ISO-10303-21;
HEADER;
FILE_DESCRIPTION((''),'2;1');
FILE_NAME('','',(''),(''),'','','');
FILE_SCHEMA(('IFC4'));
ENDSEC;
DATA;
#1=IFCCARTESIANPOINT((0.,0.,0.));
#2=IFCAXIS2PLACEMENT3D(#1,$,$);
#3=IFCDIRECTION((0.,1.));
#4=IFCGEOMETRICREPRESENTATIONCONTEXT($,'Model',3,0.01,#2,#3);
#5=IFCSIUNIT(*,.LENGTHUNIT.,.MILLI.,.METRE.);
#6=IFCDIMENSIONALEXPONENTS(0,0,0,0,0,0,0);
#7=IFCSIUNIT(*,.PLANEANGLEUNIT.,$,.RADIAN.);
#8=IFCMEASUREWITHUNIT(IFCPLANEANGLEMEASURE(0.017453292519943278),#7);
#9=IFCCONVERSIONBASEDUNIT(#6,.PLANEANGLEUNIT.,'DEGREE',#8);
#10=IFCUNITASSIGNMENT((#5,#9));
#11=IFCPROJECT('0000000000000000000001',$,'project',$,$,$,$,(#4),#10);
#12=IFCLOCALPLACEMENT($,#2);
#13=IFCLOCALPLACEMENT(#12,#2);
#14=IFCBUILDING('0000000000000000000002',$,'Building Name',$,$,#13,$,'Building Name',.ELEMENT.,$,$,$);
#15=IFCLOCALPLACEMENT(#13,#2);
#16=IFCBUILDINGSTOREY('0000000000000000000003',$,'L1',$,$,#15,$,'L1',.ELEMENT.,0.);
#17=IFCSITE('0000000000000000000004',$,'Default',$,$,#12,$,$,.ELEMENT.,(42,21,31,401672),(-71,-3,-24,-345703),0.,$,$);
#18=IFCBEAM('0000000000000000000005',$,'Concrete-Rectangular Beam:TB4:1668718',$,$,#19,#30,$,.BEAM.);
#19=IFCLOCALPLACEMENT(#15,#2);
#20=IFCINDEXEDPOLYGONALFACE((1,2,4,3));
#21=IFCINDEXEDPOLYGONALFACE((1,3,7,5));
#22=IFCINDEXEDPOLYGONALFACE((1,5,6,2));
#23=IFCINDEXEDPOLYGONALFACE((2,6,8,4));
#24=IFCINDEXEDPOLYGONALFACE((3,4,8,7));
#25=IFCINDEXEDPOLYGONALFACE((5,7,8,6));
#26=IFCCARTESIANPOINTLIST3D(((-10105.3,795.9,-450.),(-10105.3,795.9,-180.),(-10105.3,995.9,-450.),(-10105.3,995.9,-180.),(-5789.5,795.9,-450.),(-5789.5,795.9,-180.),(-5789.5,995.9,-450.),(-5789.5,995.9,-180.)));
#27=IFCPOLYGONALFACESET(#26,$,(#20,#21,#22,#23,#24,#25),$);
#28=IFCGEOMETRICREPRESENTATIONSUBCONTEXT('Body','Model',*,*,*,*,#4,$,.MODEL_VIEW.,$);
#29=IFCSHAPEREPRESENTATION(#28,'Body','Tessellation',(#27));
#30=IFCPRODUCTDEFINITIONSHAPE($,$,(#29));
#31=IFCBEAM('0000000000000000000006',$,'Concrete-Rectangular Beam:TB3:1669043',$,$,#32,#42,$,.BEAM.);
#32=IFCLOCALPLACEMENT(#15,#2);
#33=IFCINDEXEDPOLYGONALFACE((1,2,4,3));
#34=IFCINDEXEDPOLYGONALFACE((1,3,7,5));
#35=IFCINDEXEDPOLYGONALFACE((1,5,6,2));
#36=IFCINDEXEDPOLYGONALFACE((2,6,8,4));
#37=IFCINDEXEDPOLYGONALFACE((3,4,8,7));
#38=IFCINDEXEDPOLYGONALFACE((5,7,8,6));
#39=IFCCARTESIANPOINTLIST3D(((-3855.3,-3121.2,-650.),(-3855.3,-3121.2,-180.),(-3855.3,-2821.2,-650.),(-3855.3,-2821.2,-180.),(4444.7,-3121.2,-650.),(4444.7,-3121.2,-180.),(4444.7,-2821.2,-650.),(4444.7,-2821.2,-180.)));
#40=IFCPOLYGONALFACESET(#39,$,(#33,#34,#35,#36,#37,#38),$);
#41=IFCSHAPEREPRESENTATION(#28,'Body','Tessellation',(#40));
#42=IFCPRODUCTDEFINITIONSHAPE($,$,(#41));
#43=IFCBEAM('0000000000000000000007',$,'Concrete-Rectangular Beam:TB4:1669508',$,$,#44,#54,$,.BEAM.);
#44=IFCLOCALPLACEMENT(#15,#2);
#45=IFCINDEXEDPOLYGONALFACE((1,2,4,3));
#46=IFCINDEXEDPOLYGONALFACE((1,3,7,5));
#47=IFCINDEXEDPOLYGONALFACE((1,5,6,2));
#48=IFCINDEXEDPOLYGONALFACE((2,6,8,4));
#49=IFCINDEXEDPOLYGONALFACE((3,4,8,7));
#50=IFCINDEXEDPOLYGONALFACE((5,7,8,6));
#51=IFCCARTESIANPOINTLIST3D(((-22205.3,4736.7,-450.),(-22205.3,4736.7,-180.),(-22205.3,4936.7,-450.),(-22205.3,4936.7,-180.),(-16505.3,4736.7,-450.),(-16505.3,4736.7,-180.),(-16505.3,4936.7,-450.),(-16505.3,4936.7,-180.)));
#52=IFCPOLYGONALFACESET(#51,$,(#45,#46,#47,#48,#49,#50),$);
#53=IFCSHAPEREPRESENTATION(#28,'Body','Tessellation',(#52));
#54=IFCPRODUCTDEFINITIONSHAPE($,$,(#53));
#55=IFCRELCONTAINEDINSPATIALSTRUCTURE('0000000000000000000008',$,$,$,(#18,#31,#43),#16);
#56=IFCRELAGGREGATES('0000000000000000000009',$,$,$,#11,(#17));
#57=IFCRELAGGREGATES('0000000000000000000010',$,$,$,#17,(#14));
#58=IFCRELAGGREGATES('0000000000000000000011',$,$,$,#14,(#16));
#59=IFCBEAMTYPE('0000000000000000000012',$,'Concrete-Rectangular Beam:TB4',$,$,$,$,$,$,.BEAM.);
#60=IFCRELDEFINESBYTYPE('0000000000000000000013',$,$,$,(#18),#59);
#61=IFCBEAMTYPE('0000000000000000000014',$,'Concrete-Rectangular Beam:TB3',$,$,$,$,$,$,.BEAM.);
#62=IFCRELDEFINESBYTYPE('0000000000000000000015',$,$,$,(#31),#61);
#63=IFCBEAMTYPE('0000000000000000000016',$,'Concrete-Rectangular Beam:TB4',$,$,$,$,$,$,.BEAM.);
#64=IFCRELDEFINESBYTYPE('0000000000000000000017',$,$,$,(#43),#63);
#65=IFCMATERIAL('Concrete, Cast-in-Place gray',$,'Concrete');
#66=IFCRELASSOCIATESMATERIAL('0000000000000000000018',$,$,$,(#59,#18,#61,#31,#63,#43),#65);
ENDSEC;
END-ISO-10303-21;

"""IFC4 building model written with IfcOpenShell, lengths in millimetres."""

from ifc_helpers import new_model, entity, si_unit, converted_unit, direction, frame, origin, place, context, subcontext, project, spatial, indexed_curve, outline, extrude, source, transform, mapped, material, type_object, type_shapes, element, save


model = new_model("IFC4")

# Units and contexts
model_context = context("Model", 3, precision=0.01, world=origin(), true_north=direction((0.0, 1.0)))
body_context = subcontext(model_context, "Body", "Model", "MODEL_VIEW")
ifc_project = project(units=[si_unit("LENGTHUNIT", "METRE", prefix="MILLI"), converted_unit("PLANEANGLEUNIT", "DEGREE", entity("IfcPlaneAngleMeasure", 0.017453292519943278), si_unit("PLANEANGLEUNIT", "RADIAN"), dimensions=[0, 0, 0, 0, 0, 0, 0])], contexts=[model_context])

# Site, building, storey
site_placement = place(None, origin())
site = spatial("IfcSite", under=ifc_project, at=site_placement, Name="Default", CompositionType="ELEMENT", RefLatitude=(42, 21, 31, 401672), RefLongitude=(-71, -3, -24, -345703), RefElevation=0.0)
building_placement = place(site_placement, origin())
building = spatial("IfcBuilding", under=site, at=building_placement, Name="Building Name", LongName="Building Name", CompositionType="ELEMENT")
storey_placement = place(building_placement, origin())
storey = spatial("IfcBuildingStorey", under=building, at=storey_placement, Name="L1", LongName="L1", CompositionType="ELEMENT", Elevation=0.0)

# Beams
ifc_material = material(Name="Concrete, Cast-in-Place gray", Category="Concrete")
beam_type_1 = type_object("IfcBeamType", Name="Concrete-Rectangular Beam:TB4", PredefinedType="BEAM", material=ifc_material)
shared_shape_1 = source(origin(), body_context, "Body", "SweptSolid", [
    extrude(outline(indexed_curve([(-135.0, -100.0), (135.0, -100.0), (135.0, 100.0), (-135.0, 100.0), (-135.0, -100.0)], self_intersect=False)), frame((-10105.3, 895.9, -315.0), z_axis=(1.0, 0.0, 0.0), x_axis=(0.0, 0.0, -1.0)), (0.0, 0.0, 1.0), 4315.8),
])
type_shapes(beam_type_1, [shared_shape_1])
beam_1_placement = place(storey_placement, origin())
element("IfcBeam", 1, at=beam_1_placement, inside=storey, type_object=beam_type_1, material=ifc_material, Name="Concrete-Rectangular Beam:TB4:1668718", PredefinedType="BEAM", context=body_context, shape_type="MappedRepresentation", body=[
    mapped(shared_shape_1, transform((0.0, 0.0, 0.0), scale=1.0)),
])
beam_type_2 = type_object("IfcBeamType", Name="Concrete-Rectangular Beam:TB3", PredefinedType="BEAM", material=ifc_material)
shared_shape_2 = source(origin(), body_context, "Body", "SweptSolid", [
    extrude(outline(indexed_curve([(-235.0, -150.0), (235.0, -150.0), (235.0, 150.0), (-235.0, 150.0), (-235.0, -150.0)], self_intersect=False)), frame((-3855.3, -2971.2, -415.0), z_axis=(1.0, 0.0, 0.0), x_axis=(0.0, 0.0, -1.0)), (0.0, 0.0, 1.0), 8300.0),
])
type_shapes(beam_type_2, [shared_shape_2])
beam_2_placement = place(storey_placement, origin())
element("IfcBeam", 2, at=beam_2_placement, inside=storey, type_object=beam_type_2, material=ifc_material, Name="Concrete-Rectangular Beam:TB3:1669043", PredefinedType="BEAM", context=body_context, shape_type="MappedRepresentation", body=[
    mapped(shared_shape_2, transform((0.0, 0.0, 0.0), scale=1.0)),
])
beam_type_3 = type_object("IfcBeamType", Name="Concrete-Rectangular Beam:TB4", PredefinedType="BEAM", material=ifc_material)
shared_shape_3 = source(origin(), body_context, "Body", "SweptSolid", [
    extrude(outline(indexed_curve([(-135.0, -100.0), (135.0, -100.0), (135.0, 100.0), (-135.0, 100.0), (-135.0, -100.0)], self_intersect=False)), frame((-22205.3, 4836.7, -315.0), z_axis=(1.0, 0.0, 0.0), x_axis=(0.0, 0.0, -1.0)), (0.0, 0.0, 1.0), 5700.0),
])
type_shapes(beam_type_3, [shared_shape_3])
beam_3_placement = place(storey_placement, origin())
element("IfcBeam", 3, at=beam_3_placement, inside=storey, type_object=beam_type_3, material=ifc_material, Name="Concrete-Rectangular Beam:TB4:1669508", PredefinedType="BEAM", context=body_context, shape_type="MappedRepresentation", body=[
    mapped(shared_shape_3, transform((0.0, 0.0, 0.0), scale=1.0)),
])

save(model, "model.ifc")
